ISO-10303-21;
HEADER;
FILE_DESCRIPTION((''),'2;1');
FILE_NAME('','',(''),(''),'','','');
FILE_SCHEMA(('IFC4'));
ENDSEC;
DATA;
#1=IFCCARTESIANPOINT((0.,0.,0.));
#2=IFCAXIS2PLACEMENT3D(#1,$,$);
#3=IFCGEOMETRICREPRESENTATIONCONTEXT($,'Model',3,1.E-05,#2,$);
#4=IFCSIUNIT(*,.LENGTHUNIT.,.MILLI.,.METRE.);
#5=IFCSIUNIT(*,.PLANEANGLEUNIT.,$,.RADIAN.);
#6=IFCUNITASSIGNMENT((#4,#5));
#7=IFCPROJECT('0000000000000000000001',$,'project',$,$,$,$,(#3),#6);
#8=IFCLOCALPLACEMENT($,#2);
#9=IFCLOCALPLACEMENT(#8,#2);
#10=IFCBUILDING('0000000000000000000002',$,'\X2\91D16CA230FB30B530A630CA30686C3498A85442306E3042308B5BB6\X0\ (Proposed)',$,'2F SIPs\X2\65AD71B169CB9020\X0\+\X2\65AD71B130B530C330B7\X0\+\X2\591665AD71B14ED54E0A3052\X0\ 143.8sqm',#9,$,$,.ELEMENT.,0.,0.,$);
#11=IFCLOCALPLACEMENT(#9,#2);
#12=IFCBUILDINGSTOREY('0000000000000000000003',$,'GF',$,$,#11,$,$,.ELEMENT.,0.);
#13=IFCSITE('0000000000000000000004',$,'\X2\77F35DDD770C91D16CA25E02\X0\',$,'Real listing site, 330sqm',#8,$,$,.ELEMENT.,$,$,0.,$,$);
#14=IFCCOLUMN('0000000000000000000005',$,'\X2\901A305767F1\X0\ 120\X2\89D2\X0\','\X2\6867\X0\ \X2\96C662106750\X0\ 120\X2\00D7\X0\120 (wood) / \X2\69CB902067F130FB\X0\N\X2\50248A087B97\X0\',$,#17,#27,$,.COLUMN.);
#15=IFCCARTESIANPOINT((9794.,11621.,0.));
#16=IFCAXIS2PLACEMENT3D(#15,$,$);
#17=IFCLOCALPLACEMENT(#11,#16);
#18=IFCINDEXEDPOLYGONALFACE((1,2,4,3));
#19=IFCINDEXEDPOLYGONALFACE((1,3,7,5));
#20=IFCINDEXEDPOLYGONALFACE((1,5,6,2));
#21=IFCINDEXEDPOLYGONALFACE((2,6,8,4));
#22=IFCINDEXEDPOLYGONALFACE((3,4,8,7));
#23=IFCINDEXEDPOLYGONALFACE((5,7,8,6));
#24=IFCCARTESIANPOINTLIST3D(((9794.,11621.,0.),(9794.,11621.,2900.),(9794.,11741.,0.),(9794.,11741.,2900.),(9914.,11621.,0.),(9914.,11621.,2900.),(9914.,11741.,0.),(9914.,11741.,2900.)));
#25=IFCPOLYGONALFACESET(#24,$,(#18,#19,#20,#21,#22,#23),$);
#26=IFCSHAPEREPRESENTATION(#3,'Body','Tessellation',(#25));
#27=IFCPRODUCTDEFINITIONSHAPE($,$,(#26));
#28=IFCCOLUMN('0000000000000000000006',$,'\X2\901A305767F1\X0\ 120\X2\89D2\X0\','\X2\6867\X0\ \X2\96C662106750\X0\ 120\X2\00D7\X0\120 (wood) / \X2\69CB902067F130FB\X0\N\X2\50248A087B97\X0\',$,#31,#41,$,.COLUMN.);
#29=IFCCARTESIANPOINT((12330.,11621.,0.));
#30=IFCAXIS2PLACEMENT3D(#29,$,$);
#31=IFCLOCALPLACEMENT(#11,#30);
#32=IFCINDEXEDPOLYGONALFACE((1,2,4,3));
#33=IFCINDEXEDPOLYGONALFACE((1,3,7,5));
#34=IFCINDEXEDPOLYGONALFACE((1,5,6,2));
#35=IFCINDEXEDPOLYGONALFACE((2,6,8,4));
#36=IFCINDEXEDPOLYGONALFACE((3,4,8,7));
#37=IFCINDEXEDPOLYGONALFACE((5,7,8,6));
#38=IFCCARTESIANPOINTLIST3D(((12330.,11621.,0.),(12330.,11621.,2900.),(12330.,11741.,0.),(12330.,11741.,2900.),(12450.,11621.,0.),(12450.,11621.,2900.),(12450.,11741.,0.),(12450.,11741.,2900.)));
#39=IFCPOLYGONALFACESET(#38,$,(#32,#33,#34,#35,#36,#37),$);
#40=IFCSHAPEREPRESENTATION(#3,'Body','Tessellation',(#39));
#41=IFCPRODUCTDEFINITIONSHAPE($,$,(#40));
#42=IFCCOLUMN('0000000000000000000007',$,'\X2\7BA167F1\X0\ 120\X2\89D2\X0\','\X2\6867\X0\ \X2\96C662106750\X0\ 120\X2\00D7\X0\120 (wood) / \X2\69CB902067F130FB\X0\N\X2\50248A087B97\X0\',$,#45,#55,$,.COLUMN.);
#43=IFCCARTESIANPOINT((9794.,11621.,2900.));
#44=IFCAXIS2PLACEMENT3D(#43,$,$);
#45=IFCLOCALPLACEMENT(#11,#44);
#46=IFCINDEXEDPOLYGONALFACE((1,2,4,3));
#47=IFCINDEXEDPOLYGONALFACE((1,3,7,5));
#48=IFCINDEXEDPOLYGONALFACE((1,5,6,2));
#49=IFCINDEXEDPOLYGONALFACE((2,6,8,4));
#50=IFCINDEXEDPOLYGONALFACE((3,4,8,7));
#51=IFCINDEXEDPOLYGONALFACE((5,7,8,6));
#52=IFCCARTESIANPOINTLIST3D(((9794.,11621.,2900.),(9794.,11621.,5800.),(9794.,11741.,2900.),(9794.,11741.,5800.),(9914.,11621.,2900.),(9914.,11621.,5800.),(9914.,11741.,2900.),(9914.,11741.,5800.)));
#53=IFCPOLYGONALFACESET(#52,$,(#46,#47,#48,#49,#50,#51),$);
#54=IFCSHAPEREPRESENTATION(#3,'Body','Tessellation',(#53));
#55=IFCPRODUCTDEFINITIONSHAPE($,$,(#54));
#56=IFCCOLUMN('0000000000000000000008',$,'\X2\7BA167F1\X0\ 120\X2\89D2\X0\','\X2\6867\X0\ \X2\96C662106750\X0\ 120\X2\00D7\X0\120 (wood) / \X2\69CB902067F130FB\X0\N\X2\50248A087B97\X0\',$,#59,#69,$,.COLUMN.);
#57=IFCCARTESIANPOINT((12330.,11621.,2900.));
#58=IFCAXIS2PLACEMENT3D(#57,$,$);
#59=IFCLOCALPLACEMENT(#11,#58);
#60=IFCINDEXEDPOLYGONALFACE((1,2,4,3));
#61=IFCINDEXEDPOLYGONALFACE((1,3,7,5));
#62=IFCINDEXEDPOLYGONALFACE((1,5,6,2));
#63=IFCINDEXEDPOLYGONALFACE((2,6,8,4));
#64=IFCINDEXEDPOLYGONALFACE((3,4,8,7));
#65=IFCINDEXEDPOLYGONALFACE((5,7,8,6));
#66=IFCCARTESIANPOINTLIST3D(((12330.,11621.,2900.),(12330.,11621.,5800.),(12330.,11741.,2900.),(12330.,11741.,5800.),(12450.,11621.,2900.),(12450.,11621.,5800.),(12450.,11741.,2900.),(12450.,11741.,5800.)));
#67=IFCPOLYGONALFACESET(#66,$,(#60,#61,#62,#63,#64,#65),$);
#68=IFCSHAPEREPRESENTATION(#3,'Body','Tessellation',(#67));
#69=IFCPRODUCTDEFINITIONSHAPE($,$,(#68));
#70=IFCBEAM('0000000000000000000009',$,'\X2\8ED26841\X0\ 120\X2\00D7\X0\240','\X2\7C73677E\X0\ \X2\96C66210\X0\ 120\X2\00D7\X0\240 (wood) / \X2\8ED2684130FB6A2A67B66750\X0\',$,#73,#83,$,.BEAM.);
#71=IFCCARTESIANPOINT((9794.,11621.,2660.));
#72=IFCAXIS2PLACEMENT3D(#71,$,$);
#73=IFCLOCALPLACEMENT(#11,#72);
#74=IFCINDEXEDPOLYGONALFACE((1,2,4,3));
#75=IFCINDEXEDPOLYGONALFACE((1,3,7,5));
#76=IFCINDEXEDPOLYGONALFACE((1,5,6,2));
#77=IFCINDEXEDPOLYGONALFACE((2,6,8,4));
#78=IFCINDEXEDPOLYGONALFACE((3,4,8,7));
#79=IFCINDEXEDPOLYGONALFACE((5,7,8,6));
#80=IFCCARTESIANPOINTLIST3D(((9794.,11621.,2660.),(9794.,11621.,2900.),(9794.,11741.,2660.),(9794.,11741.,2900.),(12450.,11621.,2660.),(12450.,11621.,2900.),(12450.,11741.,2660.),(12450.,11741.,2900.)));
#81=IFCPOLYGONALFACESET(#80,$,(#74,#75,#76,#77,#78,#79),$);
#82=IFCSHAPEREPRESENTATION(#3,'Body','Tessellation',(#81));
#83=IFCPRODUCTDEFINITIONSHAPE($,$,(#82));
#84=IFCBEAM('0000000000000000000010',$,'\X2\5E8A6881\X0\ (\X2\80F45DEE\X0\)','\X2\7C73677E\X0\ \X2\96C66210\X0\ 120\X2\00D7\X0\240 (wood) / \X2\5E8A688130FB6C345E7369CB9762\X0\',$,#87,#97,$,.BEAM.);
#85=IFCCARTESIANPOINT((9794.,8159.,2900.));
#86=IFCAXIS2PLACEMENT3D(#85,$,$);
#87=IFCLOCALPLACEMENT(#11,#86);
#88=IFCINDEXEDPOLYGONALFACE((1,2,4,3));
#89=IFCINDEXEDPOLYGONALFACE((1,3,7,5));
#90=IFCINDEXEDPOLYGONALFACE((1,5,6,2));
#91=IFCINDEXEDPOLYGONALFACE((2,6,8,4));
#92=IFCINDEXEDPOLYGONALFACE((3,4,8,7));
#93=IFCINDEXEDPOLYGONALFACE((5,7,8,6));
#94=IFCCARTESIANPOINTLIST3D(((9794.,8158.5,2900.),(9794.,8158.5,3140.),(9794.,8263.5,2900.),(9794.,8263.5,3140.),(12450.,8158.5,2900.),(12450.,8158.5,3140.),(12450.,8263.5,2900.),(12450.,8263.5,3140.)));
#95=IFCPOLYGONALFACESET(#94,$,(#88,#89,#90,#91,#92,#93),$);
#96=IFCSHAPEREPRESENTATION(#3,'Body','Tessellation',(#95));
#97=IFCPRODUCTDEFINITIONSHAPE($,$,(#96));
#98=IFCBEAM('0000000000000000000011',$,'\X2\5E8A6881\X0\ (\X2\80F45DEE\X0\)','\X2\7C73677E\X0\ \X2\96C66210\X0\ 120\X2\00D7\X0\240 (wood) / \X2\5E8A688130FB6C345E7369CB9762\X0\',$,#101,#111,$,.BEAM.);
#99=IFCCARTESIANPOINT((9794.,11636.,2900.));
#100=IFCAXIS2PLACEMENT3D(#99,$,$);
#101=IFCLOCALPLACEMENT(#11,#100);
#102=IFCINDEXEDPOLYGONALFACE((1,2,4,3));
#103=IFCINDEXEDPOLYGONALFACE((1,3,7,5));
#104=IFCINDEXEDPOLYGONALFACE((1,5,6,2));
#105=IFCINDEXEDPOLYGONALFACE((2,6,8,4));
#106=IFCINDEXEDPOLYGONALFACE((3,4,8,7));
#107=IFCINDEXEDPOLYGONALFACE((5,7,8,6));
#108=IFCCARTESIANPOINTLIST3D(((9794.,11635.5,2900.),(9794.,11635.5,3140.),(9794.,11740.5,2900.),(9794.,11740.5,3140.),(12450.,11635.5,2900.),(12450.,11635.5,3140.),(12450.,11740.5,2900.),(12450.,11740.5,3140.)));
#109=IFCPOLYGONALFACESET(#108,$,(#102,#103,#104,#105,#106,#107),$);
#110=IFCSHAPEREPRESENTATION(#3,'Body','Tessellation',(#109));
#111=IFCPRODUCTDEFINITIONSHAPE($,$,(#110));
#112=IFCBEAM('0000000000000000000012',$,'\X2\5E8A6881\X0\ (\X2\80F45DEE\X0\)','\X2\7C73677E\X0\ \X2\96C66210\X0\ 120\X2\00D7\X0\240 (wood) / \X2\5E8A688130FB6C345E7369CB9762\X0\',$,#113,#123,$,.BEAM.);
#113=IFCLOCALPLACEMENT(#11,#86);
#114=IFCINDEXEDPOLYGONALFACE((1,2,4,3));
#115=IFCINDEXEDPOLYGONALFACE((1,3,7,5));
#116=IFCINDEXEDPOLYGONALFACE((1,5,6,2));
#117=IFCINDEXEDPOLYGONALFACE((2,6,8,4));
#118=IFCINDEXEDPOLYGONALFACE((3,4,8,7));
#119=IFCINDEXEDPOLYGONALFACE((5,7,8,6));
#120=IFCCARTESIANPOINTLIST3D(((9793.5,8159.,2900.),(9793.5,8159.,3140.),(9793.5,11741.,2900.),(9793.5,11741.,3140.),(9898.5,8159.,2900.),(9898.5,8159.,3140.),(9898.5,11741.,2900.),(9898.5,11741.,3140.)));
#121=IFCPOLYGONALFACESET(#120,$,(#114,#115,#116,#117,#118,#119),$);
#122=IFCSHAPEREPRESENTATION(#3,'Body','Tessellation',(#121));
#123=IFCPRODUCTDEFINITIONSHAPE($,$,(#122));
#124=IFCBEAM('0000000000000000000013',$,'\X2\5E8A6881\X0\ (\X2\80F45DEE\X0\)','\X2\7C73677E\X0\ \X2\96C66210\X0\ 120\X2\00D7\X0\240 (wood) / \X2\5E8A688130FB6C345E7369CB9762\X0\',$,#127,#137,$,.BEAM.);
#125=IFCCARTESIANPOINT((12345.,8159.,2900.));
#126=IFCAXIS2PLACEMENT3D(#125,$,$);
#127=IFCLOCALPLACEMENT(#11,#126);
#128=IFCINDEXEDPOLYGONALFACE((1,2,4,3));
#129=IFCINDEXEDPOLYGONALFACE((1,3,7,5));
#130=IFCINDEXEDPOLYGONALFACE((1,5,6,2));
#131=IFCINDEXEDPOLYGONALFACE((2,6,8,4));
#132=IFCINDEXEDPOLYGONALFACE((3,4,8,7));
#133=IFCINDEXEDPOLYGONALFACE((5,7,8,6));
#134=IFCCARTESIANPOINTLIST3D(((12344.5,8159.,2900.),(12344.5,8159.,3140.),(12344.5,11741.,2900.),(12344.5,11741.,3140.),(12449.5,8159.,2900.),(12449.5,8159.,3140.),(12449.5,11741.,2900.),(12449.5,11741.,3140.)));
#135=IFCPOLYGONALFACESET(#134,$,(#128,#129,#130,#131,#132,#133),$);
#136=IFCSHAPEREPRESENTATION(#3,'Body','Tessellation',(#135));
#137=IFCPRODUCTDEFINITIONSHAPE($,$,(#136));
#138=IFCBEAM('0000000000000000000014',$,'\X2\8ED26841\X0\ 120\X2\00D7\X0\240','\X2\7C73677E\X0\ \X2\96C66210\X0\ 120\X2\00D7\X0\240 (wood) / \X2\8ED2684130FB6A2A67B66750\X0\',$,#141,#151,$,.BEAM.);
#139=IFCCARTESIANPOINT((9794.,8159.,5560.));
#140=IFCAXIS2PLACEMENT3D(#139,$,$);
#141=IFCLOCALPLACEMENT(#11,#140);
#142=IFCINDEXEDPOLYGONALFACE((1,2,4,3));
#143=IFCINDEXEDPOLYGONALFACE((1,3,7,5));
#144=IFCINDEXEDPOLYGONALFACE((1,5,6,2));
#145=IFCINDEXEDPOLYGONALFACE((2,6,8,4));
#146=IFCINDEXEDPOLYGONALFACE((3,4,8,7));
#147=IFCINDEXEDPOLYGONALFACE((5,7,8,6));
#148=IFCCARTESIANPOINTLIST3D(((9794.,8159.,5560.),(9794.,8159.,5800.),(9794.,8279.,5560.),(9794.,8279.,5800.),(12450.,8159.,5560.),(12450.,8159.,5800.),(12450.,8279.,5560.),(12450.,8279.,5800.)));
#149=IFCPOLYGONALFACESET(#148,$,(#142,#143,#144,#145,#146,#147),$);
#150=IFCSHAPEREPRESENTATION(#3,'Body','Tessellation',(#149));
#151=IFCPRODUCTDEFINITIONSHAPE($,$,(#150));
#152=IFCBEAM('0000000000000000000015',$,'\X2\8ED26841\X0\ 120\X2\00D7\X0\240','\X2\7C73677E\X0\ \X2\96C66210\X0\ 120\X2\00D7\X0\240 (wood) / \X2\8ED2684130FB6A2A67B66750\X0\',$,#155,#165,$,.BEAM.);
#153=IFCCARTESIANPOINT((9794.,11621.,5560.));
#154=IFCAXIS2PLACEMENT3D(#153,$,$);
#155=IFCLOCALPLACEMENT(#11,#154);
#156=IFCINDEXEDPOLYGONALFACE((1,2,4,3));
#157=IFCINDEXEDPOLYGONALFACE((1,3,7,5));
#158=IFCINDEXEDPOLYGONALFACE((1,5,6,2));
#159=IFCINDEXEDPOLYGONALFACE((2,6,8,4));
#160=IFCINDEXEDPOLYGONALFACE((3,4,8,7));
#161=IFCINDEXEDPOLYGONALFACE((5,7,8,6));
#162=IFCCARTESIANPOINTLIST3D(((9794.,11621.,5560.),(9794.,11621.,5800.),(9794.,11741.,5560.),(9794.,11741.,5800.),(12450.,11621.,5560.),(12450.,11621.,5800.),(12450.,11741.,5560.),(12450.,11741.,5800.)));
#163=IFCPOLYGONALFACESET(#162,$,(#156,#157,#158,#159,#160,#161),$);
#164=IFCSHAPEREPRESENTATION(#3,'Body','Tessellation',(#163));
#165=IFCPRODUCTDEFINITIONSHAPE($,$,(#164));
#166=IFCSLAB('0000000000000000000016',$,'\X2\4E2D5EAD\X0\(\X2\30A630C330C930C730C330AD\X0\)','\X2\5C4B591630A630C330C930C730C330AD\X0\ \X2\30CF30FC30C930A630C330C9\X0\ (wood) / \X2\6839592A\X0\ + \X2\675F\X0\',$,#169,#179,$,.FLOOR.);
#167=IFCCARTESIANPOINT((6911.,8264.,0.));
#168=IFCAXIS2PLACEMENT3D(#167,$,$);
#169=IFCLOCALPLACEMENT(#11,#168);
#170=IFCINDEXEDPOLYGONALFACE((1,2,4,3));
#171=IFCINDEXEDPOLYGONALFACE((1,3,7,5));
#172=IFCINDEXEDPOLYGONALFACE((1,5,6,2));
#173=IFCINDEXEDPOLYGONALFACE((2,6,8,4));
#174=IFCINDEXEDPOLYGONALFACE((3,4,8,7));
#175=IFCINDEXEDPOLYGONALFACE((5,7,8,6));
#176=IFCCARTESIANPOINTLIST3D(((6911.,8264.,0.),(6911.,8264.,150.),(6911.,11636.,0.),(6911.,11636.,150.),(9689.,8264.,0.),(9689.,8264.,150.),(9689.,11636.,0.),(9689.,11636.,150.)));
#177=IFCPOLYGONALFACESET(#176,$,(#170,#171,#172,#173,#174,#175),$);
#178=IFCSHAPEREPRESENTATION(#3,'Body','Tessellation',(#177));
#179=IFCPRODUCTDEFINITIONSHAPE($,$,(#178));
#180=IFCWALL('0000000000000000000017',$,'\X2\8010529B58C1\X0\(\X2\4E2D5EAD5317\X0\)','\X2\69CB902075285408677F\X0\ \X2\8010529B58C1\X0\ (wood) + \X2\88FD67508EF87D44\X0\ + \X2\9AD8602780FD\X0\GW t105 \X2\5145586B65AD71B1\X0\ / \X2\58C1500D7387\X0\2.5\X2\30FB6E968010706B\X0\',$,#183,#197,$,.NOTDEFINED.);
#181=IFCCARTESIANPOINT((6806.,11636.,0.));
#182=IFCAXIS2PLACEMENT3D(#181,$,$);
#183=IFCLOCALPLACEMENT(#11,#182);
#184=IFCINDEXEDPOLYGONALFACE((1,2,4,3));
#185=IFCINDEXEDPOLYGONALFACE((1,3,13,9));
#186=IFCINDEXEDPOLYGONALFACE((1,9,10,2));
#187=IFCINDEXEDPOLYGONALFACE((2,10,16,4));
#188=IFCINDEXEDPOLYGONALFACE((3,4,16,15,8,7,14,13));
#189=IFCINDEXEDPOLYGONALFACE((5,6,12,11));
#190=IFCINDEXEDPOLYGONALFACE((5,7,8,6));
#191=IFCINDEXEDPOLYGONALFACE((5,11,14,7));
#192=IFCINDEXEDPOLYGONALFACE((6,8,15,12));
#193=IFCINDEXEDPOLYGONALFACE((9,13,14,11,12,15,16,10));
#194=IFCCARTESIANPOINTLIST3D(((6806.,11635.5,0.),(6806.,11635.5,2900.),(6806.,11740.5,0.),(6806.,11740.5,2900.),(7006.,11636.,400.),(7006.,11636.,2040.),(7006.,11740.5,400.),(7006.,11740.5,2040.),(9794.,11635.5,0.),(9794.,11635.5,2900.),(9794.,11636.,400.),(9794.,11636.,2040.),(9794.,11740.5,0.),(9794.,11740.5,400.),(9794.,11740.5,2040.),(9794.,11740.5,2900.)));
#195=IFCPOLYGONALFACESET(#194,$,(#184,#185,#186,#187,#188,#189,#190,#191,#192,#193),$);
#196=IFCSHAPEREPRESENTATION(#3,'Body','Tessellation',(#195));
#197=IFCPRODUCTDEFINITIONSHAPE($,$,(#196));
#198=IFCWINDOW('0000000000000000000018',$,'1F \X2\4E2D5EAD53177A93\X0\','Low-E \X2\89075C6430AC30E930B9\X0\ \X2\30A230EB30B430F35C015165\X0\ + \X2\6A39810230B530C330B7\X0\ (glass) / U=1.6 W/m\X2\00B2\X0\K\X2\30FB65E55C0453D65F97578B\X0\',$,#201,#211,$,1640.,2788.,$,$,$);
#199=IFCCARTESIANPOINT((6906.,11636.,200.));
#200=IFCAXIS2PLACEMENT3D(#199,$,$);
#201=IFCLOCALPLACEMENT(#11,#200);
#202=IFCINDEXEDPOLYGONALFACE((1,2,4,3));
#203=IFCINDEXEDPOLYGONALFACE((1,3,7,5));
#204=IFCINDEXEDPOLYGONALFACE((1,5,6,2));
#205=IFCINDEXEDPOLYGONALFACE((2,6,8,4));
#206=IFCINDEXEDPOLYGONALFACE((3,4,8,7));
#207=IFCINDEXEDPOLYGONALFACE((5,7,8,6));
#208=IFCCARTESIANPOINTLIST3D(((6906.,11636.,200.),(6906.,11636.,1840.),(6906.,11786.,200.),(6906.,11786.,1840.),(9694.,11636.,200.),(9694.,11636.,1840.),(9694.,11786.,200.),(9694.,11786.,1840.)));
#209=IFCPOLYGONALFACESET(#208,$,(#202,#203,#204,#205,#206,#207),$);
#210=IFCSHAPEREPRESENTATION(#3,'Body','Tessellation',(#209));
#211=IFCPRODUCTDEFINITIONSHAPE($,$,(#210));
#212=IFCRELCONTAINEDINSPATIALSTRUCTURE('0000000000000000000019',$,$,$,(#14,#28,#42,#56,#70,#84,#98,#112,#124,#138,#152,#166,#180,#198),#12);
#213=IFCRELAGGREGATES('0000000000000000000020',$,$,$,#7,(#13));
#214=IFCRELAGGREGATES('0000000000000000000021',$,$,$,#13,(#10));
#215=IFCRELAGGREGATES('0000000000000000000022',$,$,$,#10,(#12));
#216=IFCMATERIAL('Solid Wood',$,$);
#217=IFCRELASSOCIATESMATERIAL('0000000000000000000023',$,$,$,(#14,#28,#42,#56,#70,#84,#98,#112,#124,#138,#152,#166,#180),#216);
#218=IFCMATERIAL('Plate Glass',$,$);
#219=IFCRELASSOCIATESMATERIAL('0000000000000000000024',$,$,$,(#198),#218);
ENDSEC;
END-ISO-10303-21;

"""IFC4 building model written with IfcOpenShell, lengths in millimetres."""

from ifc_helpers import new_model, si_unit, frame, frame_2d, origin, place, context, project, spatial, rectangle, extrude, material, element, fill, save


model = new_model("IFC4")

# Units and contexts
model_context = context("Model", 3, precision=1e-05, world=origin())
ifc_project = project(units=[si_unit("LENGTHUNIT", "METRE", prefix="MILLI"), si_unit("PLANEANGLEUNIT", "RADIAN")], contexts=[model_context])

# Site, building, storey
site_placement = place(None, origin())
site = spatial("IfcSite", under=ifc_project, at=site_placement, Name="石川県金沢市", ObjectType="Real listing site, 330sqm", CompositionType="ELEMENT", RefElevation=0.0)
building_placement = place(site_placement, origin())
building = spatial("IfcBuilding", under=site, at=building_placement, Name="金沢・サウナと水風呂のある家 (Proposed)", ObjectType="2F SIPs断熱構造+断熱サッシ+外断熱仕上げ 143.8sqm", CompositionType="ELEMENT", ElevationOfRefHeight=0.0, ElevationOfTerrain=0.0)
storey_placement = place(building_placement, origin())
storey = spatial("IfcBuildingStorey", under=building, at=storey_placement, Name="GF", CompositionType="ELEMENT", Elevation=0.0)

# Columns
ifc_material_1 = material(Name="Solid Wood")
column_1_placement = place(storey_placement, frame((9794.0, 11621.0, 0.0)))
element("IfcColumn", 1, at=column_1_placement, inside=storey, material=ifc_material_1, Name="通し柱 120角", Description="桧 集成材 120×120 (wood) / 構造柱・N値計算", PredefinedType="COLUMN", context=model_context, shape_type="SweptSolid", body=[
    extrude(rectangle(XDim=120.0, YDim=120.0, at=frame_2d((60.0, 60.0))), frame((9794.0, 11621.0, 0.0)), (0.0, 0.0, 1.0), 2900.0),
])
column_2_placement = place(storey_placement, frame((12330.0, 11621.0, 0.0)))
element("IfcColumn", 2, at=column_2_placement, inside=storey, material=ifc_material_1, Name="通し柱 120角", Description="桧 集成材 120×120 (wood) / 構造柱・N値計算", PredefinedType="COLUMN", context=model_context, shape_type="SweptSolid", body=[
    extrude(rectangle(XDim=120.0, YDim=120.0, at=frame_2d((60.0, 60.0))), frame((12330.0, 11621.0, 0.0)), (0.0, 0.0, 1.0), 2900.0),
])
column_3_placement = place(storey_placement, frame((9794.0, 11621.0, 2900.0)))
element("IfcColumn", 3, at=column_3_placement, inside=storey, material=ifc_material_1, Name="管柱 120角", Description="桧 集成材 120×120 (wood) / 構造柱・N値計算", PredefinedType="COLUMN", context=model_context, shape_type="SweptSolid", body=[
    extrude(rectangle(XDim=120.0, YDim=120.0, at=frame_2d((60.0, 60.0))), frame((9794.0, 11621.0, 2900.0)), (0.0, 0.0, 1.0), 2900.0),
])
column_4_placement = place(storey_placement, frame((12330.0, 11621.0, 2900.0)))
element("IfcColumn", 4, at=column_4_placement, inside=storey, material=ifc_material_1, Name="管柱 120角", Description="桧 集成材 120×120 (wood) / 構造柱・N値計算", PredefinedType="COLUMN", context=model_context, shape_type="SweptSolid", body=[
    extrude(rectangle(XDim=120.0, YDim=120.0, at=frame_2d((60.0, 60.0))), frame((12330.0, 11621.0, 2900.0)), (0.0, 0.0, 1.0), 2900.0),
])

# Beams
beam_1_placement = place(storey_placement, frame((9794.0, 11621.0, 2660.0)))
element("IfcBeam", 5, at=beam_1_placement, inside=storey, material=ifc_material_1, Name="軒桁 120×240", Description="米松 集成 120×240 (wood) / 軒桁・横架材", PredefinedType="BEAM", context=model_context, shape_type="SweptSolid", body=[
    extrude(rectangle(XDim=2656.0, YDim=120.0, at=frame_2d((1328.0, 60.0))), frame((9794.0, 11621.0, 2660.0)), (0.0, 0.0, 1.0), 240.0),
])
beam_2_placement = place(storey_placement, frame((9794.0, 8159.0, 2900.0)))
element("IfcBeam", 6, at=beam_2_placement, inside=storey, material=ifc_material_1, Name="床梁 (胴差)", Description="米松 集成 120×240 (wood) / 床梁・水平構面", PredefinedType="BEAM", context=model_context, shape_type="SweptSolid", body=[
    extrude(rectangle(XDim=2656.0, YDim=105.0, at=frame_2d((1328.0, 52.0))), frame((9794.0, 8159.0, 2900.0)), (0.0, 0.0, 1.0), 240.0),
])
beam_3_placement = place(storey_placement, frame((9794.0, 11636.0, 2900.0)))
element("IfcBeam", 7, at=beam_3_placement, inside=storey, material=ifc_material_1, Name="床梁 (胴差)", Description="米松 集成 120×240 (wood) / 床梁・水平構面", PredefinedType="BEAM", context=model_context, shape_type="SweptSolid", body=[
    extrude(rectangle(XDim=2656.0, YDim=105.0, at=frame_2d((1328.0, 52.0))), frame((9794.0, 11636.0, 2900.0)), (0.0, 0.0, 1.0), 240.0),
])
beam_4_placement = place(storey_placement, frame((9794.0, 8159.0, 2900.0)))
element("IfcBeam", 8, at=beam_4_placement, inside=storey, material=ifc_material_1, Name="床梁 (胴差)", Description="米松 集成 120×240 (wood) / 床梁・水平構面", PredefinedType="BEAM", context=model_context, shape_type="SweptSolid", body=[
    extrude(rectangle(XDim=105.0, YDim=3582.0, at=frame_2d((52.0, 1791.0))), frame((9794.0, 8159.0, 2900.0)), (0.0, 0.0, 1.0), 240.0),
])
beam_5_placement = place(storey_placement, frame((12345.0, 8159.0, 2900.0)))
element("IfcBeam", 9, at=beam_5_placement, inside=storey, material=ifc_material_1, Name="床梁 (胴差)", Description="米松 集成 120×240 (wood) / 床梁・水平構面", PredefinedType="BEAM", context=model_context, shape_type="SweptSolid", body=[
    extrude(rectangle(XDim=105.0, YDim=3582.0, at=frame_2d((52.0, 1791.0))), frame((12345.0, 8159.0, 2900.0)), (0.0, 0.0, 1.0), 240.0),
])
beam_6_placement = place(storey_placement, frame((9794.0, 8159.0, 5560.0)))
element("IfcBeam", 10, at=beam_6_placement, inside=storey, material=ifc_material_1, Name="軒桁 120×240", Description="米松 集成 120×240 (wood) / 軒桁・横架材", PredefinedType="BEAM", context=model_context, shape_type="SweptSolid", body=[
    extrude(rectangle(XDim=2656.0, YDim=120.0, at=frame_2d((1328.0, 60.0))), frame((9794.0, 8159.0, 5560.0)), (0.0, 0.0, 1.0), 240.0),
])
beam_7_placement = place(storey_placement, frame((9794.0, 11621.0, 5560.0)))
element("IfcBeam", 11, at=beam_7_placement, inside=storey, material=ifc_material_1, Name="軒桁 120×240", Description="米松 集成 120×240 (wood) / 軒桁・横架材", PredefinedType="BEAM", context=model_context, shape_type="SweptSolid", body=[
    extrude(rectangle(XDim=2656.0, YDim=120.0, at=frame_2d((1328.0, 60.0))), frame((9794.0, 11621.0, 5560.0)), (0.0, 0.0, 1.0), 240.0),
])

# Slab
slab_placement = place(storey_placement, frame((6911.0, 8264.0, 0.0)))
element("IfcSlab", 12, at=slab_placement, inside=storey, material=ifc_material_1, Name="中庭(ウッドデッキ)", Description="屋外ウッドデッキ ハードウッド (wood) / 根太 + 束", PredefinedType="FLOOR", context=model_context, shape_type="SweptSolid", body=[
    extrude(rectangle(XDim=2778.0, YDim=3372.0, at=frame_2d((1389.0, 1686.0))), frame((6911.0, 8264.0, 0.0)), (0.0, 0.0, 1.0), 150.0),
])

# Wall, opening, window
wall_1_placement = place(storey_placement, frame((6806.0, 11636.0, 0.0)))
wall_1 = element("IfcWall", 13, at=wall_1_placement, inside=storey, material=ifc_material_1, Name="耐力壁(中庭北)", Description="構造用合板 耐力壁 (wood) + 製材軸組 + 高性能GW t105 充填断熱 / 壁倍率2.5・準耐火", PredefinedType="NOTDEFINED", context=model_context, shape_type="SweptSolid", body=[
    extrude(rectangle(XDim=2988.0, YDim=105.0, at=frame_2d((1494.0, 52.0))), frame((6806.0, 11636.0, 0.0)), (0.0, 0.0, 1.0), 2900.0),
])
opening_1_placement = place(storey_placement, frame((6906.0, 11636.0, 200.0)))
opening_1 = element("IfcOpeningElement", 14, at=opening_1_placement, cuts=wall_1, PredefinedType="NOTDEFINED", context=model_context, shape_type="SweptSolid", body=[
    extrude(rectangle(XDim=2788.0, YDim=150.0, at=frame_2d((1394.0, 75.0))), frame((6906.0, 11636.0, 200.0)), (0.0, 0.0, 1.0), 1640.0),
])
ifc_material_2 = material(Name="Plate Glass")
window_1_placement = place(storey_placement, frame((6906.0, 11636.0, 200.0)))
window_1 = element("IfcWindow", 15, at=window_1_placement, inside=storey, material=ifc_material_2, Name="1F 中庭北窓", Description="Low-E 複層ガラス アルゴン封入 + 樹脂サッシ (glass) / U=1.6 W/m²K・日射取得型", OverallHeight=1640.0, OverallWidth=2788.0, context=model_context, shape_type="SweptSolid", body=[
    extrude(rectangle(XDim=2788.0, YDim=150.0, at=frame_2d((1394.0, 75.0))), frame((6906.0, 11636.0, 200.0)), (0.0, 0.0, 1.0), 1640.0),
])
fill(opening_1, window_1)

save(model, "model.ifc")
